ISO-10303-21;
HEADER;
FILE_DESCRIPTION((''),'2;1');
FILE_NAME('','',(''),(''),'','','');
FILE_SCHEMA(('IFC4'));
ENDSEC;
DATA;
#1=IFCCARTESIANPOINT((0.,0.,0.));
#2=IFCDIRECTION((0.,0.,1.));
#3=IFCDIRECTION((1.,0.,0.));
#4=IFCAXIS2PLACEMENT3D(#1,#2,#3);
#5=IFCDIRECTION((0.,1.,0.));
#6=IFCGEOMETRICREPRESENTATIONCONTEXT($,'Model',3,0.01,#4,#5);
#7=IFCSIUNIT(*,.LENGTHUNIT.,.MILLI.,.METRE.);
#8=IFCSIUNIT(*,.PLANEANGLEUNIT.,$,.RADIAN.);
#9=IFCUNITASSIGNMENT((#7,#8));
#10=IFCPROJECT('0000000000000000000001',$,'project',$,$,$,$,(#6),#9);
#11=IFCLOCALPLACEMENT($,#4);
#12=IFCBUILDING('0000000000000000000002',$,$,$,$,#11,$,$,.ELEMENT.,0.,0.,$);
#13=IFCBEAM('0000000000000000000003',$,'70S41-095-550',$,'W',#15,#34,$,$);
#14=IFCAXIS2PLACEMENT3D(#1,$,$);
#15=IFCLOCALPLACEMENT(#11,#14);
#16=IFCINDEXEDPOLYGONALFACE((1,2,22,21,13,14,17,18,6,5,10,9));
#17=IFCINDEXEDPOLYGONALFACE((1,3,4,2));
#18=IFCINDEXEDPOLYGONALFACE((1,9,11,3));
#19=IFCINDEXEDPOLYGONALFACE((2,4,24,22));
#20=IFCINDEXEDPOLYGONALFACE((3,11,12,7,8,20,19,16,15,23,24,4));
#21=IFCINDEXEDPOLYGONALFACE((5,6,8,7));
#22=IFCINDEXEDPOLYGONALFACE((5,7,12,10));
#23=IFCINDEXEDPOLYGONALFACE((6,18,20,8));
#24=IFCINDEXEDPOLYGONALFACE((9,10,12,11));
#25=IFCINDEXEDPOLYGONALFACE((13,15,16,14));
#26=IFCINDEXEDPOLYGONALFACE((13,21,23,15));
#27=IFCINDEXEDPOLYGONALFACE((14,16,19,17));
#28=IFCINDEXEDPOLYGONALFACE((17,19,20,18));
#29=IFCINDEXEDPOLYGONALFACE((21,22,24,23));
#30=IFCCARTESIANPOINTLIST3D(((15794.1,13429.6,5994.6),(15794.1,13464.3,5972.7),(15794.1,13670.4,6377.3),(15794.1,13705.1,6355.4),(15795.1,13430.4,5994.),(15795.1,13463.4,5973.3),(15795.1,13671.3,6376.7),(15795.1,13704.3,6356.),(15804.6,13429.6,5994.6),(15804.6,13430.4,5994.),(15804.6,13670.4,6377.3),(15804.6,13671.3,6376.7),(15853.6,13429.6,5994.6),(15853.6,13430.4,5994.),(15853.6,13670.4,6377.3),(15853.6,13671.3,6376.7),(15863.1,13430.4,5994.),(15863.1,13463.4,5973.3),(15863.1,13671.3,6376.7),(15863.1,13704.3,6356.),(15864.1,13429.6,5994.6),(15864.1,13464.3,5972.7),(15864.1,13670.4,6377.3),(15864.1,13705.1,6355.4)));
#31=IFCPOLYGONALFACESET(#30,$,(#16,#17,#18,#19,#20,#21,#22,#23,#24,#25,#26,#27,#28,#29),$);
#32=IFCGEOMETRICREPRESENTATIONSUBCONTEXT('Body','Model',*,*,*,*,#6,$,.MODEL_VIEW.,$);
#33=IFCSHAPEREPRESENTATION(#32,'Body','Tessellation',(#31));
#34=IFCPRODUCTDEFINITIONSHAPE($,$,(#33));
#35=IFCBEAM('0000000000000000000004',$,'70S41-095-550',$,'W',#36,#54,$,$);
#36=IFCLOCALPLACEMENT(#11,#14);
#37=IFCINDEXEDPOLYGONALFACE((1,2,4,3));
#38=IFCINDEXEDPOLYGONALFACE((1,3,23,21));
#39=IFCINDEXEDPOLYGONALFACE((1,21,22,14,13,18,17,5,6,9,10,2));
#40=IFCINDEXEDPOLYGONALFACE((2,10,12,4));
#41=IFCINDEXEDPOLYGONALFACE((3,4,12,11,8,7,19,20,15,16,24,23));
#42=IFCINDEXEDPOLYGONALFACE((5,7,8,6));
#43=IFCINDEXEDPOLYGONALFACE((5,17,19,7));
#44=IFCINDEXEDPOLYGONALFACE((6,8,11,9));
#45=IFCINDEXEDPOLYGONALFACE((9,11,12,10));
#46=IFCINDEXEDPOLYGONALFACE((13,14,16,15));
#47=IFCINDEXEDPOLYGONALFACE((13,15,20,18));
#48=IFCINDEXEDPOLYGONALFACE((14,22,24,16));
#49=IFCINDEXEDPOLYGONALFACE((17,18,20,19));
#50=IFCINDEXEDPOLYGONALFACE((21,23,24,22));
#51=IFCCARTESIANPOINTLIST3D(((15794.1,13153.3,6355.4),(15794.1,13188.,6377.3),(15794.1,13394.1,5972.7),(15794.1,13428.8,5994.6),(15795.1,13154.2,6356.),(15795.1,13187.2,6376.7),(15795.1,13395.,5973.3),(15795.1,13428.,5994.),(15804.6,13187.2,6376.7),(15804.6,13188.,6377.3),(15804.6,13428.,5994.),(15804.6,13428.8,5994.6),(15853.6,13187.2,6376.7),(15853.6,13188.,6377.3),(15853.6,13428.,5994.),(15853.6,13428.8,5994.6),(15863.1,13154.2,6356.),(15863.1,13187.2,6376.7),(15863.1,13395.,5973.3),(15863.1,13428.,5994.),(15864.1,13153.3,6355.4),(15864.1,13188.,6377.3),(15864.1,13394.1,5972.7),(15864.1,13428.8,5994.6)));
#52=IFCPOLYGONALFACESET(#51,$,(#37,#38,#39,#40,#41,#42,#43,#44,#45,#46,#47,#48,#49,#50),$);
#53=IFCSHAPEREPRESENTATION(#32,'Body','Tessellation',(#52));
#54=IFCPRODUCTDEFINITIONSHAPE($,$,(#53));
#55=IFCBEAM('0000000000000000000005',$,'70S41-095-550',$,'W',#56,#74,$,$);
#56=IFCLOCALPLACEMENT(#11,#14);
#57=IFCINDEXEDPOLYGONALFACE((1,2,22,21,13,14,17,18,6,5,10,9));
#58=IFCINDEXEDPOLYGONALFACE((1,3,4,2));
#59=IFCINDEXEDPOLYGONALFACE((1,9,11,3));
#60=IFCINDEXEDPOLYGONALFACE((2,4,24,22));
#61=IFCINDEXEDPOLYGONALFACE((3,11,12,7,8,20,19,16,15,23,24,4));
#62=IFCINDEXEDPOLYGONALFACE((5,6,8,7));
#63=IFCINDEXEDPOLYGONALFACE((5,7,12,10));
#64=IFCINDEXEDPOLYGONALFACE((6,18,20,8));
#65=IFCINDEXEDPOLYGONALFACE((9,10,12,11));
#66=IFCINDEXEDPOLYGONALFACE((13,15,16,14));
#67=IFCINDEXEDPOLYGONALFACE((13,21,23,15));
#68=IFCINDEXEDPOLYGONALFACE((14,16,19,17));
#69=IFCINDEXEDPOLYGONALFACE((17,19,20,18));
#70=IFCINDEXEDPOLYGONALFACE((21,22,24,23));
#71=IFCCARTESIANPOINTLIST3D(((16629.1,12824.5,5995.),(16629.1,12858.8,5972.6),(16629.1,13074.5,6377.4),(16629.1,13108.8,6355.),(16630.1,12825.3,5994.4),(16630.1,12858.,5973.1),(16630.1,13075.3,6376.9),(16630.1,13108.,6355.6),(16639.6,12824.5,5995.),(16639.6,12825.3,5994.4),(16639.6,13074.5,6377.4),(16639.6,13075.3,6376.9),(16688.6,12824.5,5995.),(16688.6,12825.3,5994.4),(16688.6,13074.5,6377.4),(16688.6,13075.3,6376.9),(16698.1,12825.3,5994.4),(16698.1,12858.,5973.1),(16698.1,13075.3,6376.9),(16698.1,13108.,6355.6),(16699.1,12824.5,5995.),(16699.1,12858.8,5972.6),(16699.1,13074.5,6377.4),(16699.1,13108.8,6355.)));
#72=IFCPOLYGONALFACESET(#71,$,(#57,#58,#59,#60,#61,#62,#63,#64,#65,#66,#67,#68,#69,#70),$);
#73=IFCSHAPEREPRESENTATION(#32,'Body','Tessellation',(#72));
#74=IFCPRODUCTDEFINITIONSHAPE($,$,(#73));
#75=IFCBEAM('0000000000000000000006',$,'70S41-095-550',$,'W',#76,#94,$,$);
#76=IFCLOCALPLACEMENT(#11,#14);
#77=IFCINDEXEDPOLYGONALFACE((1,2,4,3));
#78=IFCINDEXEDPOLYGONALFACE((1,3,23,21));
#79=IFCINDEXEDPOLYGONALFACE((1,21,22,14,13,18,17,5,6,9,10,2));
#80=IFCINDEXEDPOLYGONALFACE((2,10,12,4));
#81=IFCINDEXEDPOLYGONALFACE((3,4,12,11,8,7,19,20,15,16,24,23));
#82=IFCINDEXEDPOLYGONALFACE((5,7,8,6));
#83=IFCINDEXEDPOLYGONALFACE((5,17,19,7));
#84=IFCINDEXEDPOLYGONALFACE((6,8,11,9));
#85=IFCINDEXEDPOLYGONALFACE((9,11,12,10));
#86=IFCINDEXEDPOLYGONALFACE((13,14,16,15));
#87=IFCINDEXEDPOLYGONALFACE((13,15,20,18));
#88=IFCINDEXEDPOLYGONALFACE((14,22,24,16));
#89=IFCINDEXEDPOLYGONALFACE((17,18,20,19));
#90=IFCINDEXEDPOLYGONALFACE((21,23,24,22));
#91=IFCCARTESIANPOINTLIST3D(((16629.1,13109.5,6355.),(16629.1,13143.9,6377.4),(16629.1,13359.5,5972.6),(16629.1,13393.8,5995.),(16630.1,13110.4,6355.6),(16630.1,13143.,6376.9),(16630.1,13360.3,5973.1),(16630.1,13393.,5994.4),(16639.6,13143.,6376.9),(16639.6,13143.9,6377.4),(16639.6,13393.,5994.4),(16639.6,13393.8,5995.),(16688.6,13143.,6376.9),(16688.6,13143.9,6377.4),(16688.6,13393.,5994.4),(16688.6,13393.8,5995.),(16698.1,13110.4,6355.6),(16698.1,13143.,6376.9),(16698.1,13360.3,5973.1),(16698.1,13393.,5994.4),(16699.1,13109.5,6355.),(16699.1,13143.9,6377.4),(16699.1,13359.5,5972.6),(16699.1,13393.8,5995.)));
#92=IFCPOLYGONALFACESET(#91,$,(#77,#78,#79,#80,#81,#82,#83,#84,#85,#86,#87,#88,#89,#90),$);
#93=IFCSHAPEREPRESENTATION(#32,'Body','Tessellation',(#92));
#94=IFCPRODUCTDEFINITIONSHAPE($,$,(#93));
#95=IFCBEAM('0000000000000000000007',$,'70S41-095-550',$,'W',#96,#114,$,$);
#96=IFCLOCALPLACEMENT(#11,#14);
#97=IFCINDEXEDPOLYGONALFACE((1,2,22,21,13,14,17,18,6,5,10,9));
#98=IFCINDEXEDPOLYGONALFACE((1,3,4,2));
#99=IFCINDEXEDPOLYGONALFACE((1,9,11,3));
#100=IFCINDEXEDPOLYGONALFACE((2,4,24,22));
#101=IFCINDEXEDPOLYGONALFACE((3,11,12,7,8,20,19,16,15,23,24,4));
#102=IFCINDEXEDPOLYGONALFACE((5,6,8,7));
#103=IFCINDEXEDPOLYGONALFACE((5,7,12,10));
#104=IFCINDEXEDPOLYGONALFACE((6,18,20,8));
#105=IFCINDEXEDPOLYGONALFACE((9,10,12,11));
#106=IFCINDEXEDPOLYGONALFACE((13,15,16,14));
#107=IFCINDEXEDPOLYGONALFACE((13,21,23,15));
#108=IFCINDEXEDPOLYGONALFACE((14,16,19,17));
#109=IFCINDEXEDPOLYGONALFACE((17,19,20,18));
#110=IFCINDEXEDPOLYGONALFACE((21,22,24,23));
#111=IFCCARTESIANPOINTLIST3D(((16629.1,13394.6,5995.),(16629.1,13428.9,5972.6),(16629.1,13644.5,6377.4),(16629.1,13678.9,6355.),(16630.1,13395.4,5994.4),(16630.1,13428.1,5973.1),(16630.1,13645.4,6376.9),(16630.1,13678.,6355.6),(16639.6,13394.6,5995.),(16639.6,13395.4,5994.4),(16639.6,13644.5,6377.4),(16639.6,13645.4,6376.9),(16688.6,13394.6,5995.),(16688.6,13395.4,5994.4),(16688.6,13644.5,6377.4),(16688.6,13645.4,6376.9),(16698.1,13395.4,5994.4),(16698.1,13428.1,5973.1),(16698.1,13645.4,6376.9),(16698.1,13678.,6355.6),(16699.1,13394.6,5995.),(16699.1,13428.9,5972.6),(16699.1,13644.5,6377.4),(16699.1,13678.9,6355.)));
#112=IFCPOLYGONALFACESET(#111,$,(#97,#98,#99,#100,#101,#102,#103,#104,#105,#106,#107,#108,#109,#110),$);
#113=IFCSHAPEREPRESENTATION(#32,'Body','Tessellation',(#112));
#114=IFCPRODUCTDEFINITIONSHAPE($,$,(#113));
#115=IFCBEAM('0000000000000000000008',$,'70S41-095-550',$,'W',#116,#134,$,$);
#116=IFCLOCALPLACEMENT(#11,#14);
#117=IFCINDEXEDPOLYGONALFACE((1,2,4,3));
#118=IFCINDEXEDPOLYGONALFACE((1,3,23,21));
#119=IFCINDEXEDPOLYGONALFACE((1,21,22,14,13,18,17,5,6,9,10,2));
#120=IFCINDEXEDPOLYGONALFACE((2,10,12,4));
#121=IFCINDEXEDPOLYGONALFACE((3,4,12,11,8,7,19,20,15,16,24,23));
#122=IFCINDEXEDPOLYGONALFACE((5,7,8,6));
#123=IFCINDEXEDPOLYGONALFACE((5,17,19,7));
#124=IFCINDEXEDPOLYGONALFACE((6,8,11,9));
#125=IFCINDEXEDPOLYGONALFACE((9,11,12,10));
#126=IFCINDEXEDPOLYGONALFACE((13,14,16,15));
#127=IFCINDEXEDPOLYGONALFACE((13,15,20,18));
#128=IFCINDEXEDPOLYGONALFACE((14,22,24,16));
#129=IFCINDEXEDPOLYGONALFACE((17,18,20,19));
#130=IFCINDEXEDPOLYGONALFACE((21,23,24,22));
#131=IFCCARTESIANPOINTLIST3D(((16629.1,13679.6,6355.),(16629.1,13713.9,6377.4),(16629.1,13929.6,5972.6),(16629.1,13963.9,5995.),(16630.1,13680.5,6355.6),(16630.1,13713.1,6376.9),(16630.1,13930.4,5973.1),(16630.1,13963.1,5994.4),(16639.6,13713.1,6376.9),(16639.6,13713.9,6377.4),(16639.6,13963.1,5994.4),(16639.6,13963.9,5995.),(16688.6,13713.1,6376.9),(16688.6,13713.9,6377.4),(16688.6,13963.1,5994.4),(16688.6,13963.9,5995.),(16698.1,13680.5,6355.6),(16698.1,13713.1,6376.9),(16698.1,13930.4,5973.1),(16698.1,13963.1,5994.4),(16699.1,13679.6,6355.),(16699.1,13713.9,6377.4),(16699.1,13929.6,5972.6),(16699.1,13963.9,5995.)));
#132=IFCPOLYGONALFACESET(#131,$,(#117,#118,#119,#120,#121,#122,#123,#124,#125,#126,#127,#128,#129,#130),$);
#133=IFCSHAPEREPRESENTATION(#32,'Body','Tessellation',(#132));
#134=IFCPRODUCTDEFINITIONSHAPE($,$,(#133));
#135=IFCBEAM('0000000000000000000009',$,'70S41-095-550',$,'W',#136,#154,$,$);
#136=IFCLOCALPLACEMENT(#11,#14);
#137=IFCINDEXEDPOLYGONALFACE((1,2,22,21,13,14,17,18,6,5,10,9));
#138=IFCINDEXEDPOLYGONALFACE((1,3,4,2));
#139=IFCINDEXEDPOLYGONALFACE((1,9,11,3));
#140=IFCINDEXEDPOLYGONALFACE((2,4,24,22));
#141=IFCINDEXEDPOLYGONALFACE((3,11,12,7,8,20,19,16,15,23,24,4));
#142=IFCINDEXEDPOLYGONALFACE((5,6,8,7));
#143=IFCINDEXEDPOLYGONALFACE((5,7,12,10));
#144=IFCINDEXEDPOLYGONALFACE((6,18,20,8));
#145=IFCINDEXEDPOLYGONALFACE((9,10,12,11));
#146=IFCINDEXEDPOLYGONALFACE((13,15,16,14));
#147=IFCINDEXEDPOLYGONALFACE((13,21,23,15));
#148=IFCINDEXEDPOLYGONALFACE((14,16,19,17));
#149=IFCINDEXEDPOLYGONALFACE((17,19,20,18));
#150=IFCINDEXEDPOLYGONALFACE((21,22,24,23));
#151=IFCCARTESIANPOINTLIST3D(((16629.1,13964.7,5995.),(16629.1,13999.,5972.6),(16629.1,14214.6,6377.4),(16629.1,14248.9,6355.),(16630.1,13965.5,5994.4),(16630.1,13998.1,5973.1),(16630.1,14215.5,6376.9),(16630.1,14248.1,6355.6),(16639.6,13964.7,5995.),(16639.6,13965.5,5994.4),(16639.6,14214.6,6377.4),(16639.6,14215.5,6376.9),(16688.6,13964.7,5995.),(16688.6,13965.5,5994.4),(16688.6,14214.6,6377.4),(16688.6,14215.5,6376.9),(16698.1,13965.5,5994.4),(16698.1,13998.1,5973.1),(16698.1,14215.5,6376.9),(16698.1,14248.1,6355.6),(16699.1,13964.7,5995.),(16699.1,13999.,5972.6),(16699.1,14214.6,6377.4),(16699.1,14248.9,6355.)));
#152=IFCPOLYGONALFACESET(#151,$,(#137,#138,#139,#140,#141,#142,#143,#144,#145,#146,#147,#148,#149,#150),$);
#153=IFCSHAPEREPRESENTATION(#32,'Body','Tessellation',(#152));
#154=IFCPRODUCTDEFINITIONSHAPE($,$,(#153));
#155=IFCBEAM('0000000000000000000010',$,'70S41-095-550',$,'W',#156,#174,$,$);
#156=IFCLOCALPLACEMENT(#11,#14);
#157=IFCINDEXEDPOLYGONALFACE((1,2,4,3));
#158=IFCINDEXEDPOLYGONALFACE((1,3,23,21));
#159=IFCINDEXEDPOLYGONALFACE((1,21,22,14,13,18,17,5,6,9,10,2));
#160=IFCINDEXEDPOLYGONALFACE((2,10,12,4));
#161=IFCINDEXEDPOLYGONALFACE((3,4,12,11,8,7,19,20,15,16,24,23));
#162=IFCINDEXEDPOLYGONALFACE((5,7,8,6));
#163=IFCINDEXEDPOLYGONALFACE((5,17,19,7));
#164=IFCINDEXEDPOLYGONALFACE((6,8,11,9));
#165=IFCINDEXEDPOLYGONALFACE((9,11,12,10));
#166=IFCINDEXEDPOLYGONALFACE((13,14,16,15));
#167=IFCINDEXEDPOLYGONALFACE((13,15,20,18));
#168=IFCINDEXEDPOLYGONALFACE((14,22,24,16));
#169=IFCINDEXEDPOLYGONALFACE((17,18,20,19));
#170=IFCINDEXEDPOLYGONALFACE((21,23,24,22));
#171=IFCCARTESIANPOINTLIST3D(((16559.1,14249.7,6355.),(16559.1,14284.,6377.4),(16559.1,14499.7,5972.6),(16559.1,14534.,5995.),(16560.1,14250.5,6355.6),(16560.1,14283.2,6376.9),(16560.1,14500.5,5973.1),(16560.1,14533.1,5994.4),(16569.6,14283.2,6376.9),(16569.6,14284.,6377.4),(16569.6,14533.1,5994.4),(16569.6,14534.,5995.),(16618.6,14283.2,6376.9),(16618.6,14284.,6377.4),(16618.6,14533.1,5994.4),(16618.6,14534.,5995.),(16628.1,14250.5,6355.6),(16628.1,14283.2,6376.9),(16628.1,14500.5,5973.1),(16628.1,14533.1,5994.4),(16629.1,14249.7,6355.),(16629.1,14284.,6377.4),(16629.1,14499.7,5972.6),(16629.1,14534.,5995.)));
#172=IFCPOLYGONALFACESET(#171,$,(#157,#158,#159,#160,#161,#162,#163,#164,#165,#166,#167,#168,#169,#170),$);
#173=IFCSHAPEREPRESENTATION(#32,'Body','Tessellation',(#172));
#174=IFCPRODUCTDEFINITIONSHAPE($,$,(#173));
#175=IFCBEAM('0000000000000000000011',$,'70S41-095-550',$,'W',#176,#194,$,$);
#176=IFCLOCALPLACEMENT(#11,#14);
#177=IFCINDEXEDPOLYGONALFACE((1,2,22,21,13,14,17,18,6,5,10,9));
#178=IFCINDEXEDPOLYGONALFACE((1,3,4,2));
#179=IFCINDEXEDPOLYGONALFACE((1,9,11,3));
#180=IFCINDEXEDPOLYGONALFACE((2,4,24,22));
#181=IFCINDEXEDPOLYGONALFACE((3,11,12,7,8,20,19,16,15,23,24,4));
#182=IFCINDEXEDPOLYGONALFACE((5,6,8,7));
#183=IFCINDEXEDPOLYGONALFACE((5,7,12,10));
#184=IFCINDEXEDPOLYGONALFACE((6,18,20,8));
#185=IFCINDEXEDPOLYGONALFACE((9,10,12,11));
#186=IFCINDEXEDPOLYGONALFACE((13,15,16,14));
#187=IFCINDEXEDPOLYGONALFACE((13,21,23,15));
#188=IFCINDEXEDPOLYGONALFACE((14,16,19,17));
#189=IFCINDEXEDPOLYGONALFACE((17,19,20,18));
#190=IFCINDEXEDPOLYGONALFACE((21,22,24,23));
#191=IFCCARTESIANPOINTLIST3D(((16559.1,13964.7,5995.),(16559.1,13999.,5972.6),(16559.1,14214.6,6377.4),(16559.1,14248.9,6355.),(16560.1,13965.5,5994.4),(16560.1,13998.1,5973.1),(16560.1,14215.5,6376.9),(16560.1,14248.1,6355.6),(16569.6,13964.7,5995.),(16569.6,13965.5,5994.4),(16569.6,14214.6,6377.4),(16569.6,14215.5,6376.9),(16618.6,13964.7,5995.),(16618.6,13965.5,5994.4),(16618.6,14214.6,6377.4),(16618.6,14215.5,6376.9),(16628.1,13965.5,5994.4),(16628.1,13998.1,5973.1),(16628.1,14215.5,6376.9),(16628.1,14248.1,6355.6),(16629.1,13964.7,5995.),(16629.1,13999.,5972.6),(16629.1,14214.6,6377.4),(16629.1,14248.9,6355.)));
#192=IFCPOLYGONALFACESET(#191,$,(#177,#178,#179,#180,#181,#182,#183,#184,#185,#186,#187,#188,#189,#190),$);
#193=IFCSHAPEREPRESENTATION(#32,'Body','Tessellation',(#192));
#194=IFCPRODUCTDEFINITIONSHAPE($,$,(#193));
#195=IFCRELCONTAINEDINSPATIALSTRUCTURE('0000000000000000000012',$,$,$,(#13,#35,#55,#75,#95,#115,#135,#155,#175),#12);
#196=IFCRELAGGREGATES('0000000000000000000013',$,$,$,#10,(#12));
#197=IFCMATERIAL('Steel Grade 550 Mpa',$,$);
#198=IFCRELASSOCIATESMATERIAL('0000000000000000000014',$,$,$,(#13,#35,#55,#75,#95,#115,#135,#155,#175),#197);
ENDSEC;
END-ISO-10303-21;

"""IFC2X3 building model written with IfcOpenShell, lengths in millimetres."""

from ifc_helpers import new_model, si_unit, direction, frame, origin, origin_with_axes, origin_2d_with_axis, place, context, subcontext, project, spatial, c_section, extrude, source, transform, mapped, material, element, save


model = new_model("IFC2X3")

# Units and contexts
model_context = context("Model", 3, precision=0.01, world=origin_with_axes(), true_north=direction((0.0, 1.0, 0.0)))
body_context = subcontext(model_context, "Body", "Model", "MODEL_VIEW")
ifc_project = project(units=[si_unit("LENGTHUNIT", "METRE", prefix="MILLI"), si_unit("PLANEANGLEUNIT", "RADIAN")], contexts=[model_context])

# Building
building_placement = place(None, origin_with_axes())
building = spatial("IfcBuilding", under=ifc_project, at=building_placement, CompositionType="ELEMENT", ElevationOfRefHeight=0.0, ElevationOfTerrain=0.0)

# Shared definitions
ifc_material = material(Name="Steel Grade 550 Mpa")

# Beams
shared_shape_1 = source(origin(), body_context, "Body", "SweptSolid", [
    extrude(c_section(Depth=70.0, Width=41.0, WallThickness=1.0, Girth=10.5, at=origin_2d_with_axis()), origin_with_axes(), (0.0, 0.0, 1.0), 452.2),
])
beam_1_placement = place(None, frame((15829.1, 13446.9, 5983.7), z_axis=(0.0, 0.532581, 0.846379), x_axis=(0.0, -0.846379, 0.532581)))
element("IfcBeam", 1, at=beam_1_placement, inside=building, material=ifc_material, Name="70S41-095-550", ObjectType="W", context=body_context, shape_type="MappedRepresentation", body=[
    mapped(shared_shape_1, transform((0.0, 0.0, 0.0), scale=1.0)),
])
shared_shape_2 = source(origin(), body_context, "Body", "SweptSolid", [
    extrude(c_section(Depth=70.0, Width=41.0, WallThickness=1.0, Girth=10.5, at=origin_2d_with_axis()), origin_with_axes(), (0.0, 0.0, 1.0), 452.2),
])
beam_2_placement = place(None, frame((15829.1, 13170.7, 6366.3), z_axis=(0.0, 0.532581, -0.846379), x_axis=(0.0, 0.846379, 0.532581)))
element("IfcBeam", 2, at=beam_2_placement, inside=building, material=ifc_material, Name="70S41-095-550", ObjectType="W", context=body_context, shape_type="MappedRepresentation", body=[
    mapped(shared_shape_2, transform((0.0, 0.0, 0.0), scale=1.0)),
])
shared_shape_3 = source(origin(), body_context, "Body", "SweptSolid", [
    extrude(c_section(Depth=70.0, Width=41.0, WallThickness=1.0, Girth=10.5, at=origin_2d_with_axis()), origin_with_axes(), (0.0, 0.0, 1.0), 456.9),
])
beam_3_placement = place(None, frame((16664.1, 13091.6, 6366.2), z_axis=(0.0, -0.547116, -0.837057), x_axis=(0.0, -0.837057, 0.547116)))
element("IfcBeam", 3, at=beam_3_placement, inside=building, material=ifc_material, Name="70S41-095-550", ObjectType="W", context=body_context, shape_type="MappedRepresentation", body=[
    mapped(shared_shape_3, transform((0.0, 0.0, 0.0), scale=1.0)),
])
shared_shape_4 = source(origin(), body_context, "Body", "SweptSolid", [
    extrude(c_section(Depth=70.0, Width=41.0, WallThickness=1.0, Girth=10.5, at=origin_2d_with_axis()), origin_with_axes(), (0.0, 0.0, 1.0), 456.9),
])
beam_4_placement = place(None, frame((16664.1, 13376.7, 5983.8), z_axis=(0.0, -0.547116, 0.837057), x_axis=(0.0, 0.837057, 0.547116)))
element("IfcBeam", 4, at=beam_4_placement, inside=building, material=ifc_material, Name="70S41-095-550", ObjectType="W", context=body_context, shape_type="MappedRepresentation", body=[
    mapped(shared_shape_4, transform((0.0, 0.0, 0.0), scale=1.0)),
])
shared_shape_5 = source(origin(), body_context, "Body", "SweptSolid", [
    extrude(c_section(Depth=70.0, Width=41.0, WallThickness=1.0, Girth=10.5, at=origin_2d_with_axis()), origin_with_axes(), (0.0, 0.0, 1.0), 456.9),
])
beam_5_placement = place(None, frame((16664.1, 13661.7, 6366.2), z_axis=(0.0, -0.547116, -0.837057), x_axis=(0.0, -0.837057, 0.547116)))
element("IfcBeam", 5, at=beam_5_placement, inside=building, material=ifc_material, Name="70S41-095-550", ObjectType="W", context=body_context, shape_type="MappedRepresentation", body=[
    mapped(shared_shape_5, transform((0.0, 0.0, 0.0), scale=1.0)),
])
shared_shape_6 = source(origin(), body_context, "Body", "SweptSolid", [
    extrude(c_section(Depth=70.0, Width=41.0, WallThickness=1.0, Girth=10.5, at=origin_2d_with_axis()), origin_with_axes(), (0.0, 0.0, 1.0), 456.9),
])
beam_6_placement = place(None, frame((16664.1, 13946.7, 5983.8), z_axis=(0.0, -0.547116, 0.837057), x_axis=(0.0, 0.837057, 0.547116)))
element("IfcBeam", 6, at=beam_6_placement, inside=building, material=ifc_material, Name="70S41-095-550", ObjectType="W", context=body_context, shape_type="MappedRepresentation", body=[
    mapped(shared_shape_6, transform((0.0, 0.0, 0.0), scale=1.0)),
])
shared_shape_7 = source(origin(), body_context, "Body", "SweptSolid", [
    extrude(c_section(Depth=70.0, Width=41.0, WallThickness=1.0, Girth=10.5, at=origin_2d_with_axis()), origin_with_axes(), (0.0, 0.0, 1.0), 456.9),
])
beam_7_placement = place(None, frame((16664.1, 14231.8, 6366.2), z_axis=(0.0, -0.547116, -0.837057), x_axis=(0.0, -0.837057, 0.547116)))
element("IfcBeam", 7, at=beam_7_placement, inside=building, material=ifc_material, Name="70S41-095-550", ObjectType="W", context=body_context, shape_type="MappedRepresentation", body=[
    mapped(shared_shape_7, transform((0.0, 0.0, 0.0), scale=1.0)),
])
shared_shape_8 = source(origin(), body_context, "Body", "SweptSolid", [
    extrude(c_section(Depth=70.0, Width=41.0, WallThickness=1.0, Girth=10.5, at=origin_2d_with_axis()), origin_with_axes(), (0.0, 0.0, 1.0), 456.9),
])
beam_8_placement = place(None, frame((16594.1, 14266.9, 6366.2), z_axis=(0.0, 0.547116, -0.837057), x_axis=(0.0, 0.837057, 0.547116)))
element("IfcBeam", 8, at=beam_8_placement, inside=building, material=ifc_material, Name="70S41-095-550", ObjectType="W", context=body_context, shape_type="MappedRepresentation", body=[
    mapped(shared_shape_8, transform((0.0, 0.0, 0.0), scale=1.0)),
])
shared_shape_9 = source(origin(), body_context, "Body", "SweptSolid", [
    extrude(c_section(Depth=70.0, Width=41.0, WallThickness=1.0, Girth=10.5, at=origin_2d_with_axis()), origin_with_axes(), (0.0, 0.0, 1.0), 456.9),
])
beam_9_placement = place(None, frame((16594.1, 13981.8, 5983.8), z_axis=(0.0, 0.547116, 0.837057), x_axis=(0.0, -0.837057, 0.547116)))
element("IfcBeam", 9, at=beam_9_placement, inside=building, material=ifc_material, Name="70S41-095-550", ObjectType="W", context=body_context, shape_type="MappedRepresentation", body=[
    mapped(shared_shape_9, transform((0.0, 0.0, 0.0), scale=1.0)),
])

save(model, "model.ifc")
